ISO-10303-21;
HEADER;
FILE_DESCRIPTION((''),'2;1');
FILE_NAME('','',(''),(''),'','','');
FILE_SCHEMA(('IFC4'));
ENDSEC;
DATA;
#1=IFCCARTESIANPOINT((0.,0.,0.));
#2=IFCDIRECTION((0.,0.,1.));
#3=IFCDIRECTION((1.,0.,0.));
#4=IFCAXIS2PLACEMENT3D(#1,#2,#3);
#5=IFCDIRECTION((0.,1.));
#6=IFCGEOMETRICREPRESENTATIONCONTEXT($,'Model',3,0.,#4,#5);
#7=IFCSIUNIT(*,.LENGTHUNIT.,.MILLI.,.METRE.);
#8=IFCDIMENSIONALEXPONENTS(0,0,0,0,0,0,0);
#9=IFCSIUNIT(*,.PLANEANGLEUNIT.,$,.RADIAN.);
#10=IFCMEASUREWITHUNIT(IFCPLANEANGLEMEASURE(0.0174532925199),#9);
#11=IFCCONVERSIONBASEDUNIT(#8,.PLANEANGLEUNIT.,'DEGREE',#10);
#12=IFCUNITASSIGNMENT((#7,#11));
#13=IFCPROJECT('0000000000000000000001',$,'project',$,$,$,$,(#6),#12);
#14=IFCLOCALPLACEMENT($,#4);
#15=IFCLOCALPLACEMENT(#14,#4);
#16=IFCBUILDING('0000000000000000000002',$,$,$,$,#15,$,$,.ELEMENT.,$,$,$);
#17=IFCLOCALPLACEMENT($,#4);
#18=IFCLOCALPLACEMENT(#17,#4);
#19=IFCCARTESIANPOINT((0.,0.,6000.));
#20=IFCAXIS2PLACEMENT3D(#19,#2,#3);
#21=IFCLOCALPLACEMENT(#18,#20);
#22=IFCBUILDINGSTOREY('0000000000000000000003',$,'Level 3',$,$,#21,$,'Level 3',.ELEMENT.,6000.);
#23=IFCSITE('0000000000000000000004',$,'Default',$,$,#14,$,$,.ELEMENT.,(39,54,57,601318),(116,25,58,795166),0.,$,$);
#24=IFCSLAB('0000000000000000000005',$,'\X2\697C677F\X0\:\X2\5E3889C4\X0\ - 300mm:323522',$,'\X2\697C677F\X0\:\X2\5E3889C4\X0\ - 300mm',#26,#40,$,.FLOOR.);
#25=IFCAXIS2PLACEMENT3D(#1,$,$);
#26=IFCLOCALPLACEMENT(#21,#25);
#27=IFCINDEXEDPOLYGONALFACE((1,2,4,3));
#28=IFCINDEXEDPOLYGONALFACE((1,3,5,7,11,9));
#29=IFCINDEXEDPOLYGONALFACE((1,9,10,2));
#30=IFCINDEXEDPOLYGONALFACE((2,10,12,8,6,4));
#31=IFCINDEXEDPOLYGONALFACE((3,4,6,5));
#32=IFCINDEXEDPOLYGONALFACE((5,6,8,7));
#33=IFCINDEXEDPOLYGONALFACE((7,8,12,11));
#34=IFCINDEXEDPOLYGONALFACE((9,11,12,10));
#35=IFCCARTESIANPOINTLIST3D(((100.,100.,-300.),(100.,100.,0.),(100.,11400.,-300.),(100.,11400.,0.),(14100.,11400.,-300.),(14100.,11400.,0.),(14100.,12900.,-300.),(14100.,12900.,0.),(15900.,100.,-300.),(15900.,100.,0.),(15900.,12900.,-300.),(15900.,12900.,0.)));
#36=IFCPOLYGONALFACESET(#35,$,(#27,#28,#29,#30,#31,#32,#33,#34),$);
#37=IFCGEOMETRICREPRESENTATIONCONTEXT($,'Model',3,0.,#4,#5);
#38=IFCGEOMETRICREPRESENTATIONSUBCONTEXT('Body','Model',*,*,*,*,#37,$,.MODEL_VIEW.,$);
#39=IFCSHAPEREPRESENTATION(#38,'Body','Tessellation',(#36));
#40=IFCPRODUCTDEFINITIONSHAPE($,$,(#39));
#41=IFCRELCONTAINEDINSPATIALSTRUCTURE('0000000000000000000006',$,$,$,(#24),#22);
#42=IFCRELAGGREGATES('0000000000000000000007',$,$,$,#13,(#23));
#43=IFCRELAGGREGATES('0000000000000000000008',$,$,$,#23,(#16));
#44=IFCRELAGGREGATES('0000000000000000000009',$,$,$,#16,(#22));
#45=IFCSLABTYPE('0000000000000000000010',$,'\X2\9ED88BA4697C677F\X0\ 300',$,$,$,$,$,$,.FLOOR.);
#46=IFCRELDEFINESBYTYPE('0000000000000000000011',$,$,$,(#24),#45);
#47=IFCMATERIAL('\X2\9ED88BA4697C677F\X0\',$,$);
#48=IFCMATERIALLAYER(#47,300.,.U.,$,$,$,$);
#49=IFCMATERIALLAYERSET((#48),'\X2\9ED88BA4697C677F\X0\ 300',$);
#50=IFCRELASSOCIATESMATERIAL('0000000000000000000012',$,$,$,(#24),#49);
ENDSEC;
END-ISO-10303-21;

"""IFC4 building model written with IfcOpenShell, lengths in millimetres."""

from ifc_helpers import new_model, entity, si_unit, converted_unit, direction, frame, origin_with_axes, place, context, subcontext, project, spatial, polyline, outline, extrude, material, layer, layer_set, layer_usage, type_object, element, save


model = new_model("IFC4")

# Units and contexts
model_context_1 = context("Model", 3, precision=0.0, world=origin_with_axes(), true_north=direction((0.0, 1.0)))
model_context_2 = context("Model", 3, precision=0.0, world=origin_with_axes(), true_north=direction((0.0, 1.0)))
body_context = subcontext(model_context_2, "Body", "Model", "MODEL_VIEW")
ifc_project = project(units=[si_unit("LENGTHUNIT", "METRE", prefix="MILLI"), converted_unit("PLANEANGLEUNIT", "DEGREE", entity("IfcPlaneAngleMeasure", 0.0174532925199), si_unit("PLANEANGLEUNIT", "RADIAN"), dimensions=[0, 0, 0, 0, 0, 0, 0])], contexts=[model_context_1])

# Site, building, storey
site_placement = place(None, origin_with_axes())
site = spatial("IfcSite", under=ifc_project, at=site_placement, Name="Default", CompositionType="ELEMENT", RefLatitude=(39, 54, 57, 601318), RefLongitude=(116, 25, 58, 795166), RefElevation=0.0)
building_placement = place(site_placement, origin_with_axes())
building = spatial("IfcBuilding", under=site, at=building_placement, CompositionType="ELEMENT")
placement_1 = place(None, origin_with_axes())
placement_2 = place(placement_1, origin_with_axes())
storey_placement = place(placement_2, frame((0.0, 0.0, 6000.0), z_axis=(0.0, 0.0, 1.0), x_axis=(1.0, 0.0, 0.0)))
storey = spatial("IfcBuildingStorey", under=building, at=storey_placement, Name="Level 3", LongName="Level 3", CompositionType="ELEMENT", Elevation=6000.0)

# Slab
ifc_material = material(Name="默认楼板")
ifc_layer = layer(ifc_material, 300.0, ventilated="UNKNOWN")
ifc_layer_set = layer_set([ifc_layer], Name="默认楼板 300")
ifc_layer_usage = layer_usage(ifc_layer_set, "AXIS3", "NEGATIVE", 300.0)
slab_type = type_object("IfcSlabType", Name="默认楼板 300", PredefinedType="FLOOR")
slab_placement = place(storey_placement, frame((100.0, 100.0, 0.0), z_axis=(0.0, 0.0, 1.0), x_axis=(1.0, 0.0, 0.0)))
element("IfcSlab", 1, at=slab_placement, inside=storey, type_object=slab_type, material=ifc_layer_usage, Name="楼板:常规 - 300mm:323522", ObjectType="楼板:常规 - 300mm", PredefinedType="FLOOR", context=body_context, shape_type="SweptSolid", body=[
    extrude(outline(polyline([(0.0, 0.0), (15800.0, 0.0), (15800.0, 12800.0), (14000.0, 12800.0), (14000.0, 11300.0), (0.0, 11300.0), (0.0, 0.0)])), frame((0.0, 0.0, -300.0), z_axis=(0.0, 0.0, 1.0), x_axis=(1.0, 0.0, 0.0)), (0.0, 0.0, 1.0), 300.0),
])

save(model, "model.ifc")
